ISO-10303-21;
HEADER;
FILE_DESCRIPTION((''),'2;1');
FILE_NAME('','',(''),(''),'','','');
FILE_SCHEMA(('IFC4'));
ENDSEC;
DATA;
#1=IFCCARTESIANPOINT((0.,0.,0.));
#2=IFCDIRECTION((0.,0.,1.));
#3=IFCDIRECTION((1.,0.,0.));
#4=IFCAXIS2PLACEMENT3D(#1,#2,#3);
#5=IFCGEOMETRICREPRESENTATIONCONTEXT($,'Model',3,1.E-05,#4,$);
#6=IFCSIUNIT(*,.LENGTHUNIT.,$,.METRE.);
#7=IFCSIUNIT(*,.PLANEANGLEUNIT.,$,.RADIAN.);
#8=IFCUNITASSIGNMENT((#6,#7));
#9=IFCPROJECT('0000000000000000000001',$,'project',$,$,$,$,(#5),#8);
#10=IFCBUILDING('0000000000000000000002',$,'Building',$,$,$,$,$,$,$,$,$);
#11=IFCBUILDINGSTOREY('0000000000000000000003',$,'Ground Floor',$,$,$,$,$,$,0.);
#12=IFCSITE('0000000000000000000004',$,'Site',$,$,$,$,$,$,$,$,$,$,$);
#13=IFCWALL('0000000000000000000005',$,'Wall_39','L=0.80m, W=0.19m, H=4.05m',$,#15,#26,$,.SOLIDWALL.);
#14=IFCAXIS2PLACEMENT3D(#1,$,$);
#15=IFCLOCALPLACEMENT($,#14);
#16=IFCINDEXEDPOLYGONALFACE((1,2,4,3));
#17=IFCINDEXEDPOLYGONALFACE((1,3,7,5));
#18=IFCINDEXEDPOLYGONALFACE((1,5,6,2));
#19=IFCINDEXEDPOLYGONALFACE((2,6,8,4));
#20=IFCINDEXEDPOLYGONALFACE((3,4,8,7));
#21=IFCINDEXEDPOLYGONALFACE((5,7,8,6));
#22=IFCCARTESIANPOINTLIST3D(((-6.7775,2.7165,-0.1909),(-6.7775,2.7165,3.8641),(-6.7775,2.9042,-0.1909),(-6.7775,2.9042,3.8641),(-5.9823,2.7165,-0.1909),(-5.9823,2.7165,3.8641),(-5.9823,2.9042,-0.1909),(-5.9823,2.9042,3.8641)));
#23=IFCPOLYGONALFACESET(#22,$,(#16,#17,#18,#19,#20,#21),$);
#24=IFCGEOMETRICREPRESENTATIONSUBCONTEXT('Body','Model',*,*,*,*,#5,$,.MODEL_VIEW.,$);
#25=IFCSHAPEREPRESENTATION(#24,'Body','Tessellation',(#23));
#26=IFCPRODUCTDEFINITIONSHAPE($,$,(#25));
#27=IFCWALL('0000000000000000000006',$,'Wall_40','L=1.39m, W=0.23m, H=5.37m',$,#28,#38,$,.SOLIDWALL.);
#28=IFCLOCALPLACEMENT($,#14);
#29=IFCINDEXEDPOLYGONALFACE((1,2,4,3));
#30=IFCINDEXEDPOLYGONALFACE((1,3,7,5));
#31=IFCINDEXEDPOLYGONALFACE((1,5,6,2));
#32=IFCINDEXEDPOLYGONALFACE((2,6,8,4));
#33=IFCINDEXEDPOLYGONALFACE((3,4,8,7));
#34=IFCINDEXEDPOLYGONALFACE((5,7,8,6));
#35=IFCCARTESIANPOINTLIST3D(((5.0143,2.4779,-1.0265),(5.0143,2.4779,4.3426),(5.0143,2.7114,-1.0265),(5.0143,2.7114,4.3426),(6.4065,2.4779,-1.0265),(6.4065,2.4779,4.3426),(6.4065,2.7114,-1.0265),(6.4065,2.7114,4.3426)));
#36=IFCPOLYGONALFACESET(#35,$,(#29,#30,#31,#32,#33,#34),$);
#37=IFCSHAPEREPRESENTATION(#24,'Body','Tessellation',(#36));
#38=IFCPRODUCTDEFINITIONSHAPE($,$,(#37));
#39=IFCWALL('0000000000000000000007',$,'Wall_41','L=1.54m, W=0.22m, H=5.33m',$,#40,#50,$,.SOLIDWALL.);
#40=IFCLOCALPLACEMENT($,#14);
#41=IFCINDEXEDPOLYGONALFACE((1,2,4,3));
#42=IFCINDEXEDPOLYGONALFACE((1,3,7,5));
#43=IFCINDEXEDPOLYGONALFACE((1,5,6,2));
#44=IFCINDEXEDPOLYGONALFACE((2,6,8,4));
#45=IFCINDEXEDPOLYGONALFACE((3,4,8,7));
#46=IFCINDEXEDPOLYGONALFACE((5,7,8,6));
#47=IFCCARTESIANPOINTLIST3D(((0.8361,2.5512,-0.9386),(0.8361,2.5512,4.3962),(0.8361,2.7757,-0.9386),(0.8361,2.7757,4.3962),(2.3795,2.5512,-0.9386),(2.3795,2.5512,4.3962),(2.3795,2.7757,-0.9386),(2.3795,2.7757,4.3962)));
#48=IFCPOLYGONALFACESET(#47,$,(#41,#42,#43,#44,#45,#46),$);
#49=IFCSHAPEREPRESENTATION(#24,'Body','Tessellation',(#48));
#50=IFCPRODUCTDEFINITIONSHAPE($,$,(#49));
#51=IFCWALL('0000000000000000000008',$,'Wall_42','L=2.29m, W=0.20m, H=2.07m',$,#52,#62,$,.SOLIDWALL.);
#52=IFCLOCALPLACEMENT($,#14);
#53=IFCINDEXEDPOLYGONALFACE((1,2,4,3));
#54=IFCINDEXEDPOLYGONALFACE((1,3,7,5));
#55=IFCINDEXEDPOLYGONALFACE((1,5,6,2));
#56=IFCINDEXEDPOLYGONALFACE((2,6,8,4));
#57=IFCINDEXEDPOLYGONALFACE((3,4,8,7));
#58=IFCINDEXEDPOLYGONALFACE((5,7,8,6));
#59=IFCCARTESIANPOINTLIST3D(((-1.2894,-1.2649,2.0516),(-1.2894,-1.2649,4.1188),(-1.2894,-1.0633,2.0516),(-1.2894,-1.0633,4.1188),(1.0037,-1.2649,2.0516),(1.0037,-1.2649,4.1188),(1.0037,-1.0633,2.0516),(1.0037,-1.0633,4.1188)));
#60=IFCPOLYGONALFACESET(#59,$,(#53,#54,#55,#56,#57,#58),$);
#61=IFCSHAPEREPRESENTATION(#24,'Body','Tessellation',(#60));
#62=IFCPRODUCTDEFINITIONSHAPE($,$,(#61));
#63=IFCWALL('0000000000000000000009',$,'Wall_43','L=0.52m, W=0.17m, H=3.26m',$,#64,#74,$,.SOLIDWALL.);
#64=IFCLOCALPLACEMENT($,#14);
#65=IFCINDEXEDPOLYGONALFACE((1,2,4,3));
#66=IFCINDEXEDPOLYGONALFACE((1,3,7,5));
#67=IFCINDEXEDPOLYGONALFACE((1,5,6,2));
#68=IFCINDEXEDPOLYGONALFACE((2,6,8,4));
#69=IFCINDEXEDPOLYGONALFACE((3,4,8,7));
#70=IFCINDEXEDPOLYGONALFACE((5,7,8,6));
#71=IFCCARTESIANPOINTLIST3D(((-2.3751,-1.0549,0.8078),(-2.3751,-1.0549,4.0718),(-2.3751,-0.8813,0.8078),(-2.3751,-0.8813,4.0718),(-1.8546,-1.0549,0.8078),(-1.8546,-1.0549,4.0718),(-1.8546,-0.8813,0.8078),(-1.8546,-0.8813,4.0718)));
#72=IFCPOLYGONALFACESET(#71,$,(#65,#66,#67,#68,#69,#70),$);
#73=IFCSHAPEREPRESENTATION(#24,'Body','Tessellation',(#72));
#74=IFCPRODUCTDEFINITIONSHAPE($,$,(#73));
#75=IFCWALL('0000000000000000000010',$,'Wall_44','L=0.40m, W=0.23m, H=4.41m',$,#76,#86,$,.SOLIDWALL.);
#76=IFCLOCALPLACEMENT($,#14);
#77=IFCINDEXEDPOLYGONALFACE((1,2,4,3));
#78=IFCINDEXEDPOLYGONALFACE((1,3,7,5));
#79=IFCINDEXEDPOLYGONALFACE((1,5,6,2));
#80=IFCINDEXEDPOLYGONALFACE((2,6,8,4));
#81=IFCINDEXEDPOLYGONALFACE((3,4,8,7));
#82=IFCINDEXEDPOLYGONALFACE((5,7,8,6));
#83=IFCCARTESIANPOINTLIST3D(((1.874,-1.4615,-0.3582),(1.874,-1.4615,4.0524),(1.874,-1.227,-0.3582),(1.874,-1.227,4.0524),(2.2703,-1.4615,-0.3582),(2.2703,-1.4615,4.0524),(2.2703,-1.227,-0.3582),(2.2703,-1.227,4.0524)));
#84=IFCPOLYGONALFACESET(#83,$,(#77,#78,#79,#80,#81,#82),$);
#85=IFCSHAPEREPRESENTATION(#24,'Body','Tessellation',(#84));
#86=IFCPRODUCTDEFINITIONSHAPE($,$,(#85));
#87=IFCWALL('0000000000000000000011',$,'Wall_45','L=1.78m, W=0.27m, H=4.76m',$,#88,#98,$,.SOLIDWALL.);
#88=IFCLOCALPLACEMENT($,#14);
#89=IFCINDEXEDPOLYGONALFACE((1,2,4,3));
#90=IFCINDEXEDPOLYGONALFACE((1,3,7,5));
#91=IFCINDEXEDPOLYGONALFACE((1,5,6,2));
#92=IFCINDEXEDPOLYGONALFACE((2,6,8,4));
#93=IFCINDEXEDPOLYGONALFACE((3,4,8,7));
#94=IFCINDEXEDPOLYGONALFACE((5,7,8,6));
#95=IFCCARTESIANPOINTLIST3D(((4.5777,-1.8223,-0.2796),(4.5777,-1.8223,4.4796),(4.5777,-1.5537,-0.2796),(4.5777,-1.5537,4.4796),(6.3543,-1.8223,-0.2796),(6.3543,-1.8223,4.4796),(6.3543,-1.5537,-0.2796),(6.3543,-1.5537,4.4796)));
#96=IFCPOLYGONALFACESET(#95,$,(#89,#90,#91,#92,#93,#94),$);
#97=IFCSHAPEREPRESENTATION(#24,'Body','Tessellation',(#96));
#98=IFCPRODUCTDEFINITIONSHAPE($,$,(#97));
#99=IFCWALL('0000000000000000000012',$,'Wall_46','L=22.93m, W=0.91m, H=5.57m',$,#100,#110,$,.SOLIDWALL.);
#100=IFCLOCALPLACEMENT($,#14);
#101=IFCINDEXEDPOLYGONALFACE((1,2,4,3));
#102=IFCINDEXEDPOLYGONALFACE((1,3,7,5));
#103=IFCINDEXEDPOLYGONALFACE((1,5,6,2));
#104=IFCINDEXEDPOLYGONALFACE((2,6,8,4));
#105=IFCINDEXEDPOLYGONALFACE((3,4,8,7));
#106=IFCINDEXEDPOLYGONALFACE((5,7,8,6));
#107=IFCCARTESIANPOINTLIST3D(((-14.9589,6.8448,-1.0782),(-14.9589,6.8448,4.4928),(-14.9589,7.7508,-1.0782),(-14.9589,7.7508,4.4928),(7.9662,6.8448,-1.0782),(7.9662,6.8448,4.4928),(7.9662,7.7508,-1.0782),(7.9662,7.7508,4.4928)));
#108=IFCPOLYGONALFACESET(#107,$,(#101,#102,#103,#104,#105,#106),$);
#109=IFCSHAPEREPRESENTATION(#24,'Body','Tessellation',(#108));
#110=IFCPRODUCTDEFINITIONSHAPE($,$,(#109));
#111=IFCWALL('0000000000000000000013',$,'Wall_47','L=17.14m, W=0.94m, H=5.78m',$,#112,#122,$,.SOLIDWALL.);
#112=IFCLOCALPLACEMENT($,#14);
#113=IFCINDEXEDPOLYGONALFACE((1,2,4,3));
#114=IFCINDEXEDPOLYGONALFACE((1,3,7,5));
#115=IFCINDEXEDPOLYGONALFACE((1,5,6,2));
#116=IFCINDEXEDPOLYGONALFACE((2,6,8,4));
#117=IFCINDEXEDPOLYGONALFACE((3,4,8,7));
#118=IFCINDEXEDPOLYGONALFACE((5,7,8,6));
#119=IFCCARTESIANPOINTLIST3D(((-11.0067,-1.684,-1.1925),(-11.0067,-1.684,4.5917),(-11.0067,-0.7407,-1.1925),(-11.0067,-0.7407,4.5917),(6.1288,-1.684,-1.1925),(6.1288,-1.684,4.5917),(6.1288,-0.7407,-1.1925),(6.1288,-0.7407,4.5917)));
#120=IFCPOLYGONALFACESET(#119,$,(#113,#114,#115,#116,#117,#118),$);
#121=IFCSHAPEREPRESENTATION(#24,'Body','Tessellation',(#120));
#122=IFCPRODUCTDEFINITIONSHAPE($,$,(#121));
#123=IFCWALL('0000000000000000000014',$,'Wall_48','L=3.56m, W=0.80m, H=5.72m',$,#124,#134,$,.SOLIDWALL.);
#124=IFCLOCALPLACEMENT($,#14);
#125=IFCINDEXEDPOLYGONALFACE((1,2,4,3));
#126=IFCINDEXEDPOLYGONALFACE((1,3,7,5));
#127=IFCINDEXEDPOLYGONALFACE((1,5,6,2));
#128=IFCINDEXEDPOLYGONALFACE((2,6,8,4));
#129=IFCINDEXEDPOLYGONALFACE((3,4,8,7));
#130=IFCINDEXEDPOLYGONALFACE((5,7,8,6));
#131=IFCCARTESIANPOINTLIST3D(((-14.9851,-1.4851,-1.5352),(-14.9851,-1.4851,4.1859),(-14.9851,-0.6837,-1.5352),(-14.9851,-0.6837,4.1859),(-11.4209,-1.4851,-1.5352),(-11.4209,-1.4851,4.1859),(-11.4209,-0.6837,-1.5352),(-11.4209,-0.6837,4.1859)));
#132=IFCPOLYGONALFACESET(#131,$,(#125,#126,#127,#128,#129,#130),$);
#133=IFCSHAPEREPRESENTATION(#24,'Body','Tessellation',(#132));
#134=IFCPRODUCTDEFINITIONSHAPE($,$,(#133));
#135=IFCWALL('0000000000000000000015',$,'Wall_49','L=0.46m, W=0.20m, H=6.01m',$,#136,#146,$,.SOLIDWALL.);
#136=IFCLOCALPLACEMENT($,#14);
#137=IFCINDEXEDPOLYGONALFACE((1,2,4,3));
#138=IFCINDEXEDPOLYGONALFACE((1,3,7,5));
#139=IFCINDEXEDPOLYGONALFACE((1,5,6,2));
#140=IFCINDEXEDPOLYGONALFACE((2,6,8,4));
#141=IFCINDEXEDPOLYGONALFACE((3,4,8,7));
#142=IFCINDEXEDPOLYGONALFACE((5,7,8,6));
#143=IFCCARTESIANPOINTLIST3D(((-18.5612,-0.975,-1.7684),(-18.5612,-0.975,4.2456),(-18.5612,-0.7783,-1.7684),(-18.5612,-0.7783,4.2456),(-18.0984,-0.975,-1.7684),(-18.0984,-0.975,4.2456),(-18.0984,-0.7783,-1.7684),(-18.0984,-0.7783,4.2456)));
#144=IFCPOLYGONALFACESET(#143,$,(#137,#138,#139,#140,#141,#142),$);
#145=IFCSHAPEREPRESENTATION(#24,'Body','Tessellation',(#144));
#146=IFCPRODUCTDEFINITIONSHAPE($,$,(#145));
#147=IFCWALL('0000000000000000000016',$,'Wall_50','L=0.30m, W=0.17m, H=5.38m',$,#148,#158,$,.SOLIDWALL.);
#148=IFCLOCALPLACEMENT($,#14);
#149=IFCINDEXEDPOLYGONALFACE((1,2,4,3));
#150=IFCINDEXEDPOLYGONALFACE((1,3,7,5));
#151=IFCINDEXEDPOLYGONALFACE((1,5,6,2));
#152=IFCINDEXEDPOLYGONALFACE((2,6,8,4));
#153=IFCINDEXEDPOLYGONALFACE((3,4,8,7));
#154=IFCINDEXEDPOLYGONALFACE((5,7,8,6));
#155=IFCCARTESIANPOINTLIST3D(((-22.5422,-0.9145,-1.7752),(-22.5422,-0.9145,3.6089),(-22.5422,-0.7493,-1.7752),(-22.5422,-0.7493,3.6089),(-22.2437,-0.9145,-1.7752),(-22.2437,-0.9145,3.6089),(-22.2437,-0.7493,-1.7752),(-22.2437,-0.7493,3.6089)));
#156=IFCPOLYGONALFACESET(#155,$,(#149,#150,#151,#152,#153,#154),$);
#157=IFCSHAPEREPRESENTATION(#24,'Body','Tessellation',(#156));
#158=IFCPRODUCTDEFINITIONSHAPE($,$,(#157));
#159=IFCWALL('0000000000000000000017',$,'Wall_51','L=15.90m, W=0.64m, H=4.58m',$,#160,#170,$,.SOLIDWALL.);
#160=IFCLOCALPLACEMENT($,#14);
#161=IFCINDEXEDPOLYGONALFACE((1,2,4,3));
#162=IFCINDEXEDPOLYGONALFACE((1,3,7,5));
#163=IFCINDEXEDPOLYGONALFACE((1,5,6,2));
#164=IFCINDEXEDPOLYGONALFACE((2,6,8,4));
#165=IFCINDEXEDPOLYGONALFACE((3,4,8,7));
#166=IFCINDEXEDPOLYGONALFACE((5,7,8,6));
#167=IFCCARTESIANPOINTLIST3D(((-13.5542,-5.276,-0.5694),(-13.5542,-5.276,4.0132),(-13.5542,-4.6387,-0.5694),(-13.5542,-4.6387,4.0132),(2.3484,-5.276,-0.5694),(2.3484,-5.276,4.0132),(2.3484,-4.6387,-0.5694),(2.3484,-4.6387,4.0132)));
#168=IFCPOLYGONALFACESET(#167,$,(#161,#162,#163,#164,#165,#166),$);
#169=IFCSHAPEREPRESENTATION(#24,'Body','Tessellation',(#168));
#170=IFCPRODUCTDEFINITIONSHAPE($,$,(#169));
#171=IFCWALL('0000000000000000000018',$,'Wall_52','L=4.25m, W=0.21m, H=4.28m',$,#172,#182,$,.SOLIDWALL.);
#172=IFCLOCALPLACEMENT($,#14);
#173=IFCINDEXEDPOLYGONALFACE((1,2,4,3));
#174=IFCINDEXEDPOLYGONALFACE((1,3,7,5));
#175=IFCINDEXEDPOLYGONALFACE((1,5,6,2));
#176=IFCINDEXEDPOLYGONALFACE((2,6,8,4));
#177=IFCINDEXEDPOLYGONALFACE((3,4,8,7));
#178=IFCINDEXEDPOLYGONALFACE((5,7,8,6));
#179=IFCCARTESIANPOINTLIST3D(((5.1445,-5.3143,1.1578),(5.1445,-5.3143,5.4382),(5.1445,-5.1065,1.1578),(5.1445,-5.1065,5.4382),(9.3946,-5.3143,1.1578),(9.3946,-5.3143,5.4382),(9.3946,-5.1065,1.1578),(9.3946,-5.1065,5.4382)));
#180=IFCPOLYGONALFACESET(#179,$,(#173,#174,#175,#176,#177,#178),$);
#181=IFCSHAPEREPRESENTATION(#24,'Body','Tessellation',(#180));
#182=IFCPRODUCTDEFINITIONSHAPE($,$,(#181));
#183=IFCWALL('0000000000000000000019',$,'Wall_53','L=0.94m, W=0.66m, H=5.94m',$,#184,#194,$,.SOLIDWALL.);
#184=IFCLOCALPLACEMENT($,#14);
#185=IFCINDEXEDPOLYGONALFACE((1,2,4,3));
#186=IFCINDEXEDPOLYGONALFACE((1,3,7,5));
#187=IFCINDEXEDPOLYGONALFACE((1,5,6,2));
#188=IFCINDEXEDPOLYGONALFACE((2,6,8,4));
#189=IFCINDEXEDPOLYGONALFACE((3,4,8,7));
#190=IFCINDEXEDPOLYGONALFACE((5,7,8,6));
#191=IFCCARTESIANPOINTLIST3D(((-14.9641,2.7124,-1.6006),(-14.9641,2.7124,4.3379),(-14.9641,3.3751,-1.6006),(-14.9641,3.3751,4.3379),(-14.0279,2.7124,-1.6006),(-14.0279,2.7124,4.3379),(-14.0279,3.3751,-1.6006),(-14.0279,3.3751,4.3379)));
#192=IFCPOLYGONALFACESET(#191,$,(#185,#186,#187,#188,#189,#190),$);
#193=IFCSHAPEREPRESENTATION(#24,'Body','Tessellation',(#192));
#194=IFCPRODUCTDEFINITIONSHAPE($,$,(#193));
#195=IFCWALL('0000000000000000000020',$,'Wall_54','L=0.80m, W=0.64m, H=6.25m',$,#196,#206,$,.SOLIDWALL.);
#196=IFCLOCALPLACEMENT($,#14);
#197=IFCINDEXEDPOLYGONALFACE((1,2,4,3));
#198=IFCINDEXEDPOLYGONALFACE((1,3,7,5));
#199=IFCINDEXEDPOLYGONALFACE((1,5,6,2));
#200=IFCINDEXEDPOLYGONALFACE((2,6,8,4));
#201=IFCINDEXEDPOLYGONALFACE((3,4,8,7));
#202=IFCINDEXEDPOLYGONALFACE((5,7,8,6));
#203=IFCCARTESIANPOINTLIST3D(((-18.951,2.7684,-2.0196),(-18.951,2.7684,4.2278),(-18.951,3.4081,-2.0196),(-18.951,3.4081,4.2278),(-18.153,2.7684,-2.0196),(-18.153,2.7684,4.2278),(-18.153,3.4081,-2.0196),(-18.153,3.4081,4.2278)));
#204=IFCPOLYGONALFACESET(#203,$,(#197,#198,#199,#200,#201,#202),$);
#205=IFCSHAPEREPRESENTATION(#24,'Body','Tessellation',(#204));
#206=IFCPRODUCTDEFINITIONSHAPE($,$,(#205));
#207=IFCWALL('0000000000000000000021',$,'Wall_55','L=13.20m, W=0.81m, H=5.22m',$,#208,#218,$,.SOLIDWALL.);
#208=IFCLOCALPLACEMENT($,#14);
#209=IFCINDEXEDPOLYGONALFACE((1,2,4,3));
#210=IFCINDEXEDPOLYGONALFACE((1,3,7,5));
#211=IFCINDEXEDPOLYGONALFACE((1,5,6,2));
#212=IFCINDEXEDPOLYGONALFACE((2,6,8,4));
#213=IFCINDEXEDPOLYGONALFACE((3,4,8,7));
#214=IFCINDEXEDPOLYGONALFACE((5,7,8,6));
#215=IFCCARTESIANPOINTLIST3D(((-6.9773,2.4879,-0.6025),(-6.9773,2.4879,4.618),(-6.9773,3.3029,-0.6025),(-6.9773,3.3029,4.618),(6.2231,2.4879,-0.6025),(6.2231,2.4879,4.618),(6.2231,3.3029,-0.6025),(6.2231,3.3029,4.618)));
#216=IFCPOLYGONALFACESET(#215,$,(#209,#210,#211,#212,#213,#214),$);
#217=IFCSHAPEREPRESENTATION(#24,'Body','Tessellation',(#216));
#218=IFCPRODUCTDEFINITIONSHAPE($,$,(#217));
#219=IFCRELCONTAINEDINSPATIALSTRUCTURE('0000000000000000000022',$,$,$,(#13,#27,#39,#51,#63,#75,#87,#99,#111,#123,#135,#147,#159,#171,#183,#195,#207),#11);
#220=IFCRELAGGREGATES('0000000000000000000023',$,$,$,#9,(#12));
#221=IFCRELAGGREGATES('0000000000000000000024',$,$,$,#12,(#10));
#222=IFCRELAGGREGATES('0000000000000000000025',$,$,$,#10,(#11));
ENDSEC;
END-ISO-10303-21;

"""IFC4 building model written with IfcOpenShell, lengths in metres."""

from ifc_helpers import new_model, si_unit, frame, origin_with_axes, origin_2d, context, subcontext, project, spatial, rectangle, extrude, element, save


model = new_model("IFC4")

# Units and contexts
model_context = context("Model", 3, precision=1e-05, world=origin_with_axes())
body_context = subcontext(model_context, "Body", "Model", "MODEL_VIEW")
ifc_project = project(units=[si_unit("LENGTHUNIT", "METRE"), si_unit("PLANEANGLEUNIT", "RADIAN")], contexts=[model_context])

# Site, building, storey
site = spatial("IfcSite", under=ifc_project, Name="Site")
building = spatial("IfcBuilding", under=site, Name="Building")
storey = spatial("IfcBuildingStorey", under=building, Name="Ground Floor", Elevation=0.0)

# Walls
element("IfcWall", 1, inside=storey, Name="Wall_39", Description="L=0.80m, W=0.19m, H=4.05m", PredefinedType="SOLIDWALL", context=body_context, shape_type="SweptSolid", body=[
    extrude(rectangle(XDim=0.7952, YDim=0.1877, at=origin_2d()), frame((-6.3799, 2.8103, -0.1909), z_axis=(0.0, 0.0, 1.0), x_axis=(1.0, 0.0, 0.0)), (0.0, 0.0, 1.0), 4.055),
])
element("IfcWall", 2, inside=storey, Name="Wall_40", Description="L=1.39m, W=0.23m, H=5.37m", PredefinedType="SOLIDWALL", context=body_context, shape_type="SweptSolid", body=[
    extrude(rectangle(XDim=1.3922, YDim=0.2334, at=origin_2d()), frame((5.7104, 2.5946, -1.0265), z_axis=(0.0, 0.0, 1.0), x_axis=(1.0, 0.0, 0.0)), (0.0, 0.0, 1.0), 5.369),
])
element("IfcWall", 3, inside=storey, Name="Wall_41", Description="L=1.54m, W=0.22m, H=5.33m", PredefinedType="SOLIDWALL", context=body_context, shape_type="SweptSolid", body=[
    extrude(rectangle(XDim=1.5434, YDim=0.2246, at=origin_2d()), frame((1.6078, 2.6634, -0.9386), z_axis=(0.0, 0.0, 1.0), x_axis=(1.0, 0.0, 0.0)), (0.0, 0.0, 1.0), 5.3348),
])
element("IfcWall", 4, inside=storey, Name="Wall_42", Description="L=2.29m, W=0.20m, H=2.07m", PredefinedType="SOLIDWALL", context=body_context, shape_type="SweptSolid", body=[
    extrude(rectangle(XDim=2.293, YDim=0.2016, at=origin_2d()), frame((-0.1429, -1.1641, 2.0516), z_axis=(0.0, 0.0, 1.0), x_axis=(1.0, 0.0, 0.0)), (0.0, 0.0, 1.0), 2.0672),
])
element("IfcWall", 5, inside=storey, Name="Wall_43", Description="L=0.52m, W=0.17m, H=3.26m", PredefinedType="SOLIDWALL", context=body_context, shape_type="SweptSolid", body=[
    extrude(rectangle(XDim=0.5205, YDim=0.1736, at=origin_2d()), frame((-2.1148, -0.9681, 0.8078), z_axis=(0.0, 0.0, 1.0), x_axis=(1.0, 0.0, 0.0)), (0.0, 0.0, 1.0), 3.264),
])
element("IfcWall", 6, inside=storey, Name="Wall_44", Description="L=0.40m, W=0.23m, H=4.41m", PredefinedType="SOLIDWALL", context=body_context, shape_type="SweptSolid", body=[
    extrude(rectangle(XDim=0.3962, YDim=0.2344, at=origin_2d()), frame((2.0721, -1.3442, -0.3582), z_axis=(0.0, 0.0, 1.0), x_axis=(1.0, 0.0, 0.0)), (0.0, 0.0, 1.0), 4.4106),
])
element("IfcWall", 7, inside=storey, Name="Wall_45", Description="L=1.78m, W=0.27m, H=4.76m", PredefinedType="SOLIDWALL", context=body_context, shape_type="SweptSolid", body=[
    extrude(rectangle(XDim=1.7765, YDim=0.2686, at=origin_2d()), frame((5.466, -1.688, -0.2796), z_axis=(0.0, 0.0, 1.0), x_axis=(1.0, 0.0, 0.0)), (0.0, 0.0, 1.0), 4.7592),
])
element("IfcWall", 8, inside=storey, Name="Wall_46", Description="L=22.93m, W=0.91m, H=5.57m", PredefinedType="SOLIDWALL", context=body_context, shape_type="SweptSolid", body=[
    extrude(rectangle(XDim=22.9251, YDim=0.906, at=origin_2d()), frame((-3.4964, 7.2978, -1.0782), z_axis=(0.0, 0.0, 1.0), x_axis=(1.0, 0.0, 0.0)), (0.0, 0.0, 1.0), 5.571),
])
element("IfcWall", 9, inside=storey, Name="Wall_47", Description="L=17.14m, W=0.94m, H=5.78m", PredefinedType="SOLIDWALL", context=body_context, shape_type="SweptSolid", body=[
    extrude(rectangle(XDim=17.1355, YDim=0.9433, at=origin_2d()), frame((-2.4389, -1.2124, -1.1925), z_axis=(0.0, 0.0, 1.0), x_axis=(1.0, 0.0, 0.0)), (0.0, 0.0, 1.0), 5.7842),
])
element("IfcWall", 10, inside=storey, Name="Wall_48", Description="L=3.56m, W=0.80m, H=5.72m", PredefinedType="SOLIDWALL", context=body_context, shape_type="SweptSolid", body=[
    extrude(rectangle(XDim=3.5642, YDim=0.8014, at=origin_2d()), frame((-13.203, -1.0844, -1.5352), z_axis=(0.0, 0.0, 1.0), x_axis=(1.0, 0.0, 0.0)), (0.0, 0.0, 1.0), 5.7211),
])
element("IfcWall", 11, inside=storey, Name="Wall_49", Description="L=0.46m, W=0.20m, H=6.01m", PredefinedType="SOLIDWALL", context=body_context, shape_type="SweptSolid", body=[
    extrude(rectangle(XDim=0.4628, YDim=0.1967, at=origin_2d()), frame((-18.3298, -0.8766, -1.7684), z_axis=(0.0, 0.0, 1.0), x_axis=(1.0, 0.0, 0.0)), (0.0, 0.0, 1.0), 6.014),
])
element("IfcWall", 12, inside=storey, Name="Wall_50", Description="L=0.30m, W=0.17m, H=5.38m", PredefinedType="SOLIDWALL", context=body_context, shape_type="SweptSolid", body=[
    extrude(rectangle(XDim=0.2985, YDim=0.1652, at=origin_2d()), frame((-22.3929, -0.8319, -1.7752), z_axis=(0.0, 0.0, 1.0), x_axis=(1.0, 0.0, 0.0)), (0.0, 0.0, 1.0), 5.3841),
])
element("IfcWall", 13, inside=storey, Name="Wall_51", Description="L=15.90m, W=0.64m, H=4.58m", PredefinedType="SOLIDWALL", context=body_context, shape_type="SweptSolid", body=[
    extrude(rectangle(XDim=15.9026, YDim=0.6373, at=origin_2d()), frame((-5.6029, -4.9573, -0.5694), z_axis=(0.0, 0.0, 1.0), x_axis=(1.0, 0.0, 0.0)), (0.0, 0.0, 1.0), 4.5827),
])
element("IfcWall", 14, inside=storey, Name="Wall_52", Description="L=4.25m, W=0.21m, H=4.28m", PredefinedType="SOLIDWALL", context=body_context, shape_type="SweptSolid", body=[
    extrude(rectangle(XDim=4.2501, YDim=0.2079, at=origin_2d()), frame((7.2695, -5.2104, 1.1578), z_axis=(0.0, 0.0, 1.0), x_axis=(1.0, 0.0, 0.0)), (0.0, 0.0, 1.0), 4.2804),
])
element("IfcWall", 15, inside=storey, Name="Wall_53", Description="L=0.94m, W=0.66m, H=5.94m", PredefinedType="SOLIDWALL", context=body_context, shape_type="SweptSolid", body=[
    extrude(rectangle(XDim=0.9362, YDim=0.6626, at=origin_2d()), frame((-14.496, 3.0438, -1.6006), z_axis=(0.0, 0.0, 1.0), x_axis=(1.0, 0.0, 0.0)), (0.0, 0.0, 1.0), 5.9385),
])
element("IfcWall", 16, inside=storey, Name="Wall_54", Description="L=0.80m, W=0.64m, H=6.25m", PredefinedType="SOLIDWALL", context=body_context, shape_type="SweptSolid", body=[
    extrude(rectangle(XDim=0.7979, YDim=0.6396, at=origin_2d()), frame((-18.552, 3.0883, -2.0196), z_axis=(0.0, 0.0, 1.0), x_axis=(1.0, 0.0, 0.0)), (0.0, 0.0, 1.0), 6.2474),
])
element("IfcWall", 17, inside=storey, Name="Wall_55", Description="L=13.20m, W=0.81m, H=5.22m", PredefinedType="SOLIDWALL", context=body_context, shape_type="SweptSolid", body=[
    extrude(rectangle(XDim=13.2003, YDim=0.815, at=origin_2d()), frame((-0.3771, 2.8954, -0.6025), z_axis=(0.0, 0.0, 1.0), x_axis=(1.0, 0.0, 0.0)), (0.0, 0.0, 1.0), 5.2206),
])

save(model, "model.ifc")
